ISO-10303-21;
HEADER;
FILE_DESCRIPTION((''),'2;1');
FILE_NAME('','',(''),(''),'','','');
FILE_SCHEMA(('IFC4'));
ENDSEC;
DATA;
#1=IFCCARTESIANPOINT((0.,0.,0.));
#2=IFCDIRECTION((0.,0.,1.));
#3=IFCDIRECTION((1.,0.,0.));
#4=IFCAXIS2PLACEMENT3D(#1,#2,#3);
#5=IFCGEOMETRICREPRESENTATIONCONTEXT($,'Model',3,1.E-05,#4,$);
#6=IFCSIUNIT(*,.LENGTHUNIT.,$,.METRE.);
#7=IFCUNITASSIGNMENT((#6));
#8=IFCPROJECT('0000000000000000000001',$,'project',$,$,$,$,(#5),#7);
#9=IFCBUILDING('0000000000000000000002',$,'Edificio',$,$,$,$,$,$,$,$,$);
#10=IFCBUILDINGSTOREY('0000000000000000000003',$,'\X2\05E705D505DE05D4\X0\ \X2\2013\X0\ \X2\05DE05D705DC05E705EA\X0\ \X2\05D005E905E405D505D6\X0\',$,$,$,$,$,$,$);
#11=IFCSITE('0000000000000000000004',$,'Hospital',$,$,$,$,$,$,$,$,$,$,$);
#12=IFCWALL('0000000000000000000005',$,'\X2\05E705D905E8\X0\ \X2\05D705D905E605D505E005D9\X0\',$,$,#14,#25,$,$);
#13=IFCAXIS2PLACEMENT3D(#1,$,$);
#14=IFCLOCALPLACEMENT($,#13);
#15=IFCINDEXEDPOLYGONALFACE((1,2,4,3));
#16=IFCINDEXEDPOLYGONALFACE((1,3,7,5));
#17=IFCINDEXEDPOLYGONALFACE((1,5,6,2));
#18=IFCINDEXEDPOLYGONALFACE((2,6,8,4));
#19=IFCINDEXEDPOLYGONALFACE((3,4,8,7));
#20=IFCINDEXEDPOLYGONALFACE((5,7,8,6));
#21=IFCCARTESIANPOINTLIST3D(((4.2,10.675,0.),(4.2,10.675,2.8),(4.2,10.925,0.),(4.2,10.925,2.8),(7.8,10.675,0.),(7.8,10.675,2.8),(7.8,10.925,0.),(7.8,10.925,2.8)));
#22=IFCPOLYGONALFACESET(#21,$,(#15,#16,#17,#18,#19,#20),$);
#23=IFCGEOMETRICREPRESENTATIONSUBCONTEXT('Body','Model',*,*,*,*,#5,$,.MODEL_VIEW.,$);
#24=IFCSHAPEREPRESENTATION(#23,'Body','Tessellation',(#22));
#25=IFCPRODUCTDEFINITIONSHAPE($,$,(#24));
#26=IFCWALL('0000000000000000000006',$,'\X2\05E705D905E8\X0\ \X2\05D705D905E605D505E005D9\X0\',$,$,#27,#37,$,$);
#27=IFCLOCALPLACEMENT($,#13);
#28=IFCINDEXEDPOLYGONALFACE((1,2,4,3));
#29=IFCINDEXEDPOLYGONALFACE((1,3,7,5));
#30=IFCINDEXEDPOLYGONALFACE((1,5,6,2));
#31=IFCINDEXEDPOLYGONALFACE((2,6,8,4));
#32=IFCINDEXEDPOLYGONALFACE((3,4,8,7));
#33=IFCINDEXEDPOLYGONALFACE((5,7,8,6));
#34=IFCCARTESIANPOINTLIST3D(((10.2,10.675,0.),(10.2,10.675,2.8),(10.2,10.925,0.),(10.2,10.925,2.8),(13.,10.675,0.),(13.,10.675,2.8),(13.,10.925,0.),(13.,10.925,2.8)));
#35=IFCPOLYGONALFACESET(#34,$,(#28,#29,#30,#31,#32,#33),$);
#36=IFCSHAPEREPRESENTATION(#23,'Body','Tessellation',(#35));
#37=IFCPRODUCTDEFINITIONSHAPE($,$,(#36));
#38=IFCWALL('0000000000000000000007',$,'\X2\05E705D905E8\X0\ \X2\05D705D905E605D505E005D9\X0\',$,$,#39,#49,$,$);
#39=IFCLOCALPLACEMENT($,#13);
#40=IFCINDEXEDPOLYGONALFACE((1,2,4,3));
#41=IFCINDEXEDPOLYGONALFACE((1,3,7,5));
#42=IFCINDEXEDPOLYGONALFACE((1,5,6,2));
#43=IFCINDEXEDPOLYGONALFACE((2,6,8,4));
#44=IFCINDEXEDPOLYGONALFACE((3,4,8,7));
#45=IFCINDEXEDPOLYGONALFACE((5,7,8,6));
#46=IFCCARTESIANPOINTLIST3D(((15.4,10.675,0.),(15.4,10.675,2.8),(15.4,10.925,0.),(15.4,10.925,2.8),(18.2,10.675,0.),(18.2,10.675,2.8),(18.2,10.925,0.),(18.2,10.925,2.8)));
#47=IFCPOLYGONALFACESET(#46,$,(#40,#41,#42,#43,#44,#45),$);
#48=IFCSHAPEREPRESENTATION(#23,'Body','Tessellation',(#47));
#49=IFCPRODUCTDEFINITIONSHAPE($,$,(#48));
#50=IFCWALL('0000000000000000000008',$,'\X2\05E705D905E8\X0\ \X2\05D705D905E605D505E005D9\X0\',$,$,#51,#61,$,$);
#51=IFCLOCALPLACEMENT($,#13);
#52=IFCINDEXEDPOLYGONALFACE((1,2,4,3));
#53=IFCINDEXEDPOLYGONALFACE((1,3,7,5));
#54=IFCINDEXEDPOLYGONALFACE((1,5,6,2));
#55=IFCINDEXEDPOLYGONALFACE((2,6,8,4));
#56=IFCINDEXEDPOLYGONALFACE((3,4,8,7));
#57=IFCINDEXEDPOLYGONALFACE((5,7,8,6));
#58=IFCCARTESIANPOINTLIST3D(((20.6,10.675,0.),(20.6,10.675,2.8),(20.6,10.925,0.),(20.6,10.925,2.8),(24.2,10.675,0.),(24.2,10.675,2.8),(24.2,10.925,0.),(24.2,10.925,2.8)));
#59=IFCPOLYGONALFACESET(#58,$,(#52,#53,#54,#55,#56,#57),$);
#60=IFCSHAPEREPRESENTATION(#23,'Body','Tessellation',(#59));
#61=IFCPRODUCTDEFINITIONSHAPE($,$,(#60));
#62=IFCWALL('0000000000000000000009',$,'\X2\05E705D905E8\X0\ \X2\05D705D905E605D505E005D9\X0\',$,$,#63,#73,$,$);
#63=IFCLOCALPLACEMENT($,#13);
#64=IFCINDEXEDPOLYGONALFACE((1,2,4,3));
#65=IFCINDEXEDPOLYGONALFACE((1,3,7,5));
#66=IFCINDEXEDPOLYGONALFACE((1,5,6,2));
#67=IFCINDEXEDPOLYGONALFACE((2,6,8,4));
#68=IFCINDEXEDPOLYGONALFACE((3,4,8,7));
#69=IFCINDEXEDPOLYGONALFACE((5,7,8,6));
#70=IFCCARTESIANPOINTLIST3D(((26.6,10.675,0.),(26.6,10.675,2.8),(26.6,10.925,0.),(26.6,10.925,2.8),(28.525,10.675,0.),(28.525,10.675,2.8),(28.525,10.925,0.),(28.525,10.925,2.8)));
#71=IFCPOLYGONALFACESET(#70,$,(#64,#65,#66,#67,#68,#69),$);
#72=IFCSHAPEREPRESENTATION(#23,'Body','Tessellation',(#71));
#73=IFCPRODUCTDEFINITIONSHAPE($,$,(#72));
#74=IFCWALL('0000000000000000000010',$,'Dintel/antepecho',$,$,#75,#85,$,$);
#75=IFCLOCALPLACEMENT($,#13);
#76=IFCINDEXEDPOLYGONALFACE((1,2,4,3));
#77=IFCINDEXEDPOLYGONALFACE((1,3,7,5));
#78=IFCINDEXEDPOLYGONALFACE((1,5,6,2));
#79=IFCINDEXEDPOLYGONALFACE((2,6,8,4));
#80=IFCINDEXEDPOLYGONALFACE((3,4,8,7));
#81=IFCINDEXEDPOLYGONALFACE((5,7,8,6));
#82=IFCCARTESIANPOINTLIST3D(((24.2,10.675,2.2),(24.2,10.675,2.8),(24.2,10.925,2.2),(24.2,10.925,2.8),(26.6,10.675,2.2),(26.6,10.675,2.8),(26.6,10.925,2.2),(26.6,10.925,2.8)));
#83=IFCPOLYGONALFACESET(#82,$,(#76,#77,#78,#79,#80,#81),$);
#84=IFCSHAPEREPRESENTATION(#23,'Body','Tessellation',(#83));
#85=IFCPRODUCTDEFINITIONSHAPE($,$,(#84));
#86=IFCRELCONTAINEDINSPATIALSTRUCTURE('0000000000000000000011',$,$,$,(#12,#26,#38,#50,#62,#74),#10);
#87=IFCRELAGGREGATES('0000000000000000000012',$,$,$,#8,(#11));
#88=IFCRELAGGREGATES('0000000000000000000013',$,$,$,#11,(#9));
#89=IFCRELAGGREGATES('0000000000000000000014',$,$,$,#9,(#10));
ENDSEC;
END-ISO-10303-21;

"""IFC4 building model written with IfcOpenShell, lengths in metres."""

from ifc_helpers import new_model, si_unit, frame, origin_with_axes, context, subcontext, project, spatial, line, indexed_curve, outline, extrude, element, save


model = new_model("IFC4")

# Units and contexts
model_context = context("Model", 3, precision=1e-05, world=origin_with_axes())
body_context = subcontext(model_context, "Body", "Model", "MODEL_VIEW")
ifc_project = project(units=[si_unit("LENGTHUNIT", "METRE")], contexts=[model_context])

# Site, building, storey
site = spatial("IfcSite", under=ifc_project, Name="Hospital")
building = spatial("IfcBuilding", under=site, Name="Edificio")
storey = spatial("IfcBuildingStorey", under=building, Name="קומה – מחלקת אשפוז")

# Walls
element("IfcWall", 1, inside=storey, Name="קיר חיצוני", context=body_context, shape_type="SweptSolid", body=[
    extrude(outline(indexed_curve([(0.0, 0.0), (3.6, 0.0), (3.6, 0.25), (0.0, 0.25)], segments=[line(1, 2, 3, 4, 1)])), frame((4.2, 10.675, 0.0), z_axis=(0.0, 0.0, 1.0), x_axis=(1.0, 0.0, 0.0)), (0.0, 0.0, 1.0), 2.8),
])
element("IfcWall", 2, inside=storey, Name="קיר חיצוני", context=body_context, shape_type="SweptSolid", body=[
    extrude(outline(indexed_curve([(0.0, 0.0), (2.8, 0.0), (2.8, 0.25), (0.0, 0.25)], segments=[line(1, 2, 3, 4, 1)])), frame((10.2, 10.675, 0.0), z_axis=(0.0, 0.0, 1.0), x_axis=(1.0, 0.0, 0.0)), (0.0, 0.0, 1.0), 2.8),
])
element("IfcWall", 3, inside=storey, Name="קיר חיצוני", context=body_context, shape_type="SweptSolid", body=[
    extrude(outline(indexed_curve([(0.0, 0.0), (2.8, 0.0), (2.8, 0.25), (0.0, 0.25)], segments=[line(1, 2, 3, 4, 1)])), frame((15.4, 10.675, 0.0), z_axis=(0.0, 0.0, 1.0), x_axis=(1.0, 0.0, 0.0)), (0.0, 0.0, 1.0), 2.8),
])
element("IfcWall", 4, inside=storey, Name="קיר חיצוני", context=body_context, shape_type="SweptSolid", body=[
    extrude(outline(indexed_curve([(0.0, 0.0), (3.6, 0.0), (3.6, 0.25), (0.0, 0.25)], segments=[line(1, 2, 3, 4, 1)])), frame((20.6, 10.675, 0.0), z_axis=(0.0, 0.0, 1.0), x_axis=(1.0, 0.0, 0.0)), (0.0, 0.0, 1.0), 2.8),
])
element("IfcWall", 5, inside=storey, Name="קיר חיצוני", context=body_context, shape_type="SweptSolid", body=[
    extrude(outline(indexed_curve([(0.0, 0.0), (1.925, 0.0), (1.925, 0.25), (0.0, 0.25)], segments=[line(1, 2, 3, 4, 1)])), frame((26.6, 10.675, 0.0), z_axis=(0.0, 0.0, 1.0), x_axis=(1.0, 0.0, 0.0)), (0.0, 0.0, 1.0), 2.8),
])
element("IfcWall", 6, inside=storey, Name="Dintel/antepecho", context=body_context, shape_type="SweptSolid", body=[
    extrude(outline(indexed_curve([(0.0, 0.0), (2.4, 0.0), (2.4, 0.25), (0.0, 0.25)], segments=[line(1, 2, 3, 4, 1)])), frame((24.2, 10.675, 2.2), z_axis=(0.0, 0.0, 1.0), x_axis=(1.0, 0.0, 0.0)), (0.0, 0.0, 1.0), 0.6),
])

save(model, "model.ifc")
